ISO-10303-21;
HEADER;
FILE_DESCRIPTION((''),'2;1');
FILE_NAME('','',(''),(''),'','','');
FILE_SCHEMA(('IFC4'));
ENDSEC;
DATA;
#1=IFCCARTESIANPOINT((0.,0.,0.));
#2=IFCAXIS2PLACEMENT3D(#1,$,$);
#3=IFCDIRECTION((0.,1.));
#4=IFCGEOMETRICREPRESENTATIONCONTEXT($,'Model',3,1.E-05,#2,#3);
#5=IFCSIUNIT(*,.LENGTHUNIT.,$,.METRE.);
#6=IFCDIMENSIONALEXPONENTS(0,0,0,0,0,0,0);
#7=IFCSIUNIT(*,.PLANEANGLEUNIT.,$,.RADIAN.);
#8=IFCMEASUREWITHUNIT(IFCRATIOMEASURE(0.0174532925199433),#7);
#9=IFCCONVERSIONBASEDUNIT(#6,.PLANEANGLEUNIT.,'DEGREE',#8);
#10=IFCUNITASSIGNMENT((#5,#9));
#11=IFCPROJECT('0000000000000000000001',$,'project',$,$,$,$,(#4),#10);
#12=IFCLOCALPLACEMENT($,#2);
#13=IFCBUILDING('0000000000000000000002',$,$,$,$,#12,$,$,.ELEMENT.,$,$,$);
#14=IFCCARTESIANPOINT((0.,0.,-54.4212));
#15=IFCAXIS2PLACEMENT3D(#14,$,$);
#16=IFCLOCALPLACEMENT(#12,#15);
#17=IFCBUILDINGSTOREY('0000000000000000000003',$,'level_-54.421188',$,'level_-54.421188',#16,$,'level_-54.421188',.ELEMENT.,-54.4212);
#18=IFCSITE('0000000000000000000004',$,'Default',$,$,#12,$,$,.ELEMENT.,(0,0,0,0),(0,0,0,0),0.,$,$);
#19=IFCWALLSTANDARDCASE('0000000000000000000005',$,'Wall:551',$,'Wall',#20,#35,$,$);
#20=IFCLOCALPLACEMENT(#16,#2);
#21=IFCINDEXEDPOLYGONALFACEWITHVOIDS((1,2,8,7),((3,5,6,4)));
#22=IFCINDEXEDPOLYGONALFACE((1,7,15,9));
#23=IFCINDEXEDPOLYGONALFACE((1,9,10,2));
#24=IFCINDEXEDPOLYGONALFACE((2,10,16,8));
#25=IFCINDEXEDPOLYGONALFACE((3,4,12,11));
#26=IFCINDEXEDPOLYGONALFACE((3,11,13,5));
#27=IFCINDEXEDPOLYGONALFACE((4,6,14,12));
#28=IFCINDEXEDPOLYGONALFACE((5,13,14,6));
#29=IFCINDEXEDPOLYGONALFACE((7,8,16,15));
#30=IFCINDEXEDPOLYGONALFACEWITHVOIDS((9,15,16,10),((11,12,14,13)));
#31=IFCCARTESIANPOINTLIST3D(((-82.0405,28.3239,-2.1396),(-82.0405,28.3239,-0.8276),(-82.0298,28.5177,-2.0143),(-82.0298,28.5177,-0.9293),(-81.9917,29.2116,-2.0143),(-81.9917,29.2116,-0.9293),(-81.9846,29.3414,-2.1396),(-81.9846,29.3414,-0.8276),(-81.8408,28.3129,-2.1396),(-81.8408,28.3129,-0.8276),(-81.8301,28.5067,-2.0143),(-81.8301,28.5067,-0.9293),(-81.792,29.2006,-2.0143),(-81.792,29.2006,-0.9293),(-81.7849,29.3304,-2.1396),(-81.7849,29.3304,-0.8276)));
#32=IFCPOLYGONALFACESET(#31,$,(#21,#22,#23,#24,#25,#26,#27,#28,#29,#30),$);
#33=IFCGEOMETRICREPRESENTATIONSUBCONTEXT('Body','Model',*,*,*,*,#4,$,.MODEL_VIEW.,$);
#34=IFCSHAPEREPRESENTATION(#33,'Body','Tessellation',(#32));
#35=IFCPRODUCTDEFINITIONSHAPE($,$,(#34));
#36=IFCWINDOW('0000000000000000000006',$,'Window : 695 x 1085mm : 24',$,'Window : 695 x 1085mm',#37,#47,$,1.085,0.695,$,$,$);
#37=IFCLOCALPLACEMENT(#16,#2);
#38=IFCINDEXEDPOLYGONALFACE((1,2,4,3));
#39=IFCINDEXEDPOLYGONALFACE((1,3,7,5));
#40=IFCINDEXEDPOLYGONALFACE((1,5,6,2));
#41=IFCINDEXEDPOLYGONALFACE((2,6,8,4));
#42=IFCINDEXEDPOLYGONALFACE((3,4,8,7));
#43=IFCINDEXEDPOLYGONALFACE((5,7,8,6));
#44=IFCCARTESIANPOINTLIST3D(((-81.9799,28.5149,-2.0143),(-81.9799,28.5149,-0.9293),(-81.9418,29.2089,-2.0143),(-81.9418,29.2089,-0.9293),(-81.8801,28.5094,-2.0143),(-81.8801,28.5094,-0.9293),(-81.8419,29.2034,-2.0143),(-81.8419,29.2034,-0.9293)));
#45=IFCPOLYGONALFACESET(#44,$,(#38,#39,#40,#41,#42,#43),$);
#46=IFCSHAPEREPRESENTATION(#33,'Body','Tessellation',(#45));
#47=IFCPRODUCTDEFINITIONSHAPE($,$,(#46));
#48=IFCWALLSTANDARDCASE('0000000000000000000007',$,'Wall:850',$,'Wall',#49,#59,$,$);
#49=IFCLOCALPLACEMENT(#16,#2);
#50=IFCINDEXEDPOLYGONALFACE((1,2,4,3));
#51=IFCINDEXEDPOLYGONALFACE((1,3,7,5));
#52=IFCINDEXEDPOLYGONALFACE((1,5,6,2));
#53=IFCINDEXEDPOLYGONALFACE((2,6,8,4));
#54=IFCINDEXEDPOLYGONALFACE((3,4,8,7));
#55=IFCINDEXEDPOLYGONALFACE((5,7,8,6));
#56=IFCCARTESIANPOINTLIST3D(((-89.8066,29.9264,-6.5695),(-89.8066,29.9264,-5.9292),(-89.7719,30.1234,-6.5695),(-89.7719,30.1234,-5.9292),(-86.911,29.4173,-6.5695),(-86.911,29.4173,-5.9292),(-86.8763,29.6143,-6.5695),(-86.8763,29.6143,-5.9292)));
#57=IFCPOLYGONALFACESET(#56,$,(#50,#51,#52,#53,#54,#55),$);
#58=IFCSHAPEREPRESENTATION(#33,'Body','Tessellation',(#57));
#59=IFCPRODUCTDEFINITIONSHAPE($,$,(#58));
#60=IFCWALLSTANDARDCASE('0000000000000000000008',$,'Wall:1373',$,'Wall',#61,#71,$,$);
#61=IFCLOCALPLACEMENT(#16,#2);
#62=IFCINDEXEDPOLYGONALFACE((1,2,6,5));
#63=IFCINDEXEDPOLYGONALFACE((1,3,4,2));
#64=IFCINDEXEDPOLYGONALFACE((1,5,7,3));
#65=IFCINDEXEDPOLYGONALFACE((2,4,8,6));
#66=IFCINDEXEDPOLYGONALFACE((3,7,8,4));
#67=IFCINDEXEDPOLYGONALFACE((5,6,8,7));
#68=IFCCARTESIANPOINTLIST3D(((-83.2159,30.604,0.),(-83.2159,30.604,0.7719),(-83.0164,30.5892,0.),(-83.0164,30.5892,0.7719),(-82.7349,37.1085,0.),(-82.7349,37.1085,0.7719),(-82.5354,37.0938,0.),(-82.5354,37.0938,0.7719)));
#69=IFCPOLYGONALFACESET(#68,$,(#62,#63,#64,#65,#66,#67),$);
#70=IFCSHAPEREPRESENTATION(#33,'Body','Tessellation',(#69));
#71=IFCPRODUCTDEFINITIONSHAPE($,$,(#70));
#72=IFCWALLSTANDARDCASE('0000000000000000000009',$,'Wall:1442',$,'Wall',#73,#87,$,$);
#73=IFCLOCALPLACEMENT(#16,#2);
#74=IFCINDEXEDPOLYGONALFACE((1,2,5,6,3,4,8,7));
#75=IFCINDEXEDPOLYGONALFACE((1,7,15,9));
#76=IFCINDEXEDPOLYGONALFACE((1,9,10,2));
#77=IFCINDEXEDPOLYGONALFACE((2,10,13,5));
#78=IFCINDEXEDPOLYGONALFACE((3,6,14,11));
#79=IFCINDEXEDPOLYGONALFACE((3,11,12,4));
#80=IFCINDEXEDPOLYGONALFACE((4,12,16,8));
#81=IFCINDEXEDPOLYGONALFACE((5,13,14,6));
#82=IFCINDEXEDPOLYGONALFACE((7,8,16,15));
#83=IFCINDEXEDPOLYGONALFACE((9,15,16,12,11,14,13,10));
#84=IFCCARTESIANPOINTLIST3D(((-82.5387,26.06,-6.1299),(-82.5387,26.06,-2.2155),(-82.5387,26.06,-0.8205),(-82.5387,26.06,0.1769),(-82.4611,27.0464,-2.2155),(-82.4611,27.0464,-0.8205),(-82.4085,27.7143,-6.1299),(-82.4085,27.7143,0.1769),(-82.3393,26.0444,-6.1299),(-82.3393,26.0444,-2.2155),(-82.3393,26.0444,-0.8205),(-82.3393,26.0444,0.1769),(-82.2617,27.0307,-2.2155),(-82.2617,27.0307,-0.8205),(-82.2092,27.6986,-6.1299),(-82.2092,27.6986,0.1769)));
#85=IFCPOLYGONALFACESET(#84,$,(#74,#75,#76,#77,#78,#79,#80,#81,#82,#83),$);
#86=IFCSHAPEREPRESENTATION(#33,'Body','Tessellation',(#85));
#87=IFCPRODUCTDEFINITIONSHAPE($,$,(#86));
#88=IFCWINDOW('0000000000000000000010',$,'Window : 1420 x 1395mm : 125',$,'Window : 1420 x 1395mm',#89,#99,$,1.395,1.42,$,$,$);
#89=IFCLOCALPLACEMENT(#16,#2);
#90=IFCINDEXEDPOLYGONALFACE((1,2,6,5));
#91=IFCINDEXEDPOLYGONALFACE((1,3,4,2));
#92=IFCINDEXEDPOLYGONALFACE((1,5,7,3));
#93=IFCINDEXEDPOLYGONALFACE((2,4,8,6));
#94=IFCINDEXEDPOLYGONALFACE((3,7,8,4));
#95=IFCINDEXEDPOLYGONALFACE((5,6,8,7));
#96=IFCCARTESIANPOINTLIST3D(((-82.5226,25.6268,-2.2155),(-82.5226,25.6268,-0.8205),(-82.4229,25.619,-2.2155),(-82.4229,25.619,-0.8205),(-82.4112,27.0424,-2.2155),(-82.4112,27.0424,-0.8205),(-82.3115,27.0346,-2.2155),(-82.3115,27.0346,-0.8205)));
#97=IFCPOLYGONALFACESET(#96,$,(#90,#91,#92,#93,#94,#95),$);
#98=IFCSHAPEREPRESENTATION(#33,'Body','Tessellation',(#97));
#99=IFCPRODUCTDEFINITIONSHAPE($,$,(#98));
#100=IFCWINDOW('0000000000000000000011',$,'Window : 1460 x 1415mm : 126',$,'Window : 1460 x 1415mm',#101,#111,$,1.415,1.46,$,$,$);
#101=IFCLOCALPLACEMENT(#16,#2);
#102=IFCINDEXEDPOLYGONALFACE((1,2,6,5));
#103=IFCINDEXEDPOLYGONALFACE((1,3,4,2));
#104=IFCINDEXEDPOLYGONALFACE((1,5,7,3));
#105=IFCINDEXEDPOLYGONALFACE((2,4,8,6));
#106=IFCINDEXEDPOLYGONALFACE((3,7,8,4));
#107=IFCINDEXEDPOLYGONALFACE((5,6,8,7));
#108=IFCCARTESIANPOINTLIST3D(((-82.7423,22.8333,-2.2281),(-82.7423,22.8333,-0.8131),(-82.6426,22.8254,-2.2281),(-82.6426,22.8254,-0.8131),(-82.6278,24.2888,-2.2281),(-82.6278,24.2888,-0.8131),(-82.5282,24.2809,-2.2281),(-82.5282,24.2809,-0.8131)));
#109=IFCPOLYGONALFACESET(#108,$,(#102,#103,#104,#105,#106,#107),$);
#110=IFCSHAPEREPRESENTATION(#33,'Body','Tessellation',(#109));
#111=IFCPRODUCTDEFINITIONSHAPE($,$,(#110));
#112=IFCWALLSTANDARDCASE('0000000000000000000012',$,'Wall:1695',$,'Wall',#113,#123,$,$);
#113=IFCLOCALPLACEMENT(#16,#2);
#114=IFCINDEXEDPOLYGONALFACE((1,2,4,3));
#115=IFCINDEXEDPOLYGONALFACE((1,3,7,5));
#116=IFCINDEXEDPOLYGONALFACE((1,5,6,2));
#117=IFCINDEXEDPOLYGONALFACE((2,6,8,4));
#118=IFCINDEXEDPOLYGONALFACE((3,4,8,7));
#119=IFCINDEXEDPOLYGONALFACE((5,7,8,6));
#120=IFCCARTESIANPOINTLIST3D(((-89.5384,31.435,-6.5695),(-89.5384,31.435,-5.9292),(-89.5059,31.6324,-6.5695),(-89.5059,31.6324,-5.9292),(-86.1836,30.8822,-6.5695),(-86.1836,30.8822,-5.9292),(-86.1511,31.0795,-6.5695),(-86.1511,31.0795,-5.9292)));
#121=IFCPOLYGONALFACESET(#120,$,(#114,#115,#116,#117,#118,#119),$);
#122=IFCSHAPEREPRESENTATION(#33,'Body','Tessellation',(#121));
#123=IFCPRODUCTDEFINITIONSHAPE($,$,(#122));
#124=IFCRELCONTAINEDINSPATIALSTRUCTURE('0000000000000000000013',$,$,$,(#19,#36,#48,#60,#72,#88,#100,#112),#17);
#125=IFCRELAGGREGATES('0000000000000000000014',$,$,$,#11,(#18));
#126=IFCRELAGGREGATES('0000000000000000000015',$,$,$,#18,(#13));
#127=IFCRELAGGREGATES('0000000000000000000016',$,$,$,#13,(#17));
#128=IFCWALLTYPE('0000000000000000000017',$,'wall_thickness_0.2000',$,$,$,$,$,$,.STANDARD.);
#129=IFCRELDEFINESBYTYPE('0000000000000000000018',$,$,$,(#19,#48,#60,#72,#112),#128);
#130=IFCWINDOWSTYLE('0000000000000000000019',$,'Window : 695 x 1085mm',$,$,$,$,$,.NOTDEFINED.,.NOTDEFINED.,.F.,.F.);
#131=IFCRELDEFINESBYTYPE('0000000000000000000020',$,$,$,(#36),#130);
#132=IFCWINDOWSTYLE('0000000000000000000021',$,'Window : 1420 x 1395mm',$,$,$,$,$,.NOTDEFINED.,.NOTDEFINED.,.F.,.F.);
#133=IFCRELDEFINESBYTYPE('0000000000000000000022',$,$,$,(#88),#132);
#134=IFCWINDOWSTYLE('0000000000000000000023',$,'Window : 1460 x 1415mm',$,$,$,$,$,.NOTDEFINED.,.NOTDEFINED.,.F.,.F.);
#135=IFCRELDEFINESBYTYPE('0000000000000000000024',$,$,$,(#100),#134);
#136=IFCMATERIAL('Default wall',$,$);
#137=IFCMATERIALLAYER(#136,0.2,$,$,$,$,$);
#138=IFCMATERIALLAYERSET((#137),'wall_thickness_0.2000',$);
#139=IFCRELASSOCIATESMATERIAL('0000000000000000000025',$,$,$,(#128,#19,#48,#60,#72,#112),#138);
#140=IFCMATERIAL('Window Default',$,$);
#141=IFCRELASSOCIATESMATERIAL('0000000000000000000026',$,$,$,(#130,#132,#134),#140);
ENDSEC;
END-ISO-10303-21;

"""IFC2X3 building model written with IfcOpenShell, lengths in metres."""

from ifc_helpers import new_model, entity, si_unit, converted_unit, direction, frame, frame_2d, origin, origin_2d_with_axis, place, context, subcontext, project, spatial, polyline, rectangle, outline, extrude, source, transform, mapped, material, layer, layer_set, layer_usage, type_object, type_shapes, element, fill, save


model = new_model("IFC2X3")

# Units and contexts
model_context = context("Model", 3, precision=1e-05, world=origin(), true_north=direction((0.0, 1.0)))
body_context = subcontext(model_context, "Body", "Model", "MODEL_VIEW")
ifc_project = project(units=[si_unit("LENGTHUNIT", "METRE"), converted_unit("PLANEANGLEUNIT", "DEGREE", entity("IfcRatioMeasure", 0.0174532925199433), si_unit("PLANEANGLEUNIT", "RADIAN"), dimensions=[0, 0, 0, 0, 0, 0, 0])], contexts=[model_context])

# Site, building, storey
placement_1 = place(None, origin())
site = spatial("IfcSite", under=ifc_project, at=placement_1, Name="Default", CompositionType="ELEMENT", RefLatitude=(0, 0, 0, 0), RefLongitude=(0, 0, 0, 0), RefElevation=0.0)
building = spatial("IfcBuilding", under=site, at=placement_1, CompositionType="ELEMENT")
storey_placement = place(placement_1, frame((0.0, 0.0, -54.4212)))
storey = spatial("IfcBuildingStorey", under=building, at=storey_placement, Name="level_-54.421188", ObjectType="level_-54.421188", LongName="level_-54.421188", CompositionType="ELEMENT", Elevation=-54.4212)

# Wall, opening, window
ifc_material_1 = material(Name="Default wall")
ifc_layer = layer(ifc_material_1, 0.2)
ifc_layer_set = layer_set([ifc_layer], Name="wall_thickness_0.2000")
ifc_layer_usage = layer_usage(ifc_layer_set, "AXIS2", "POSITIVE", -0.1)
wall_type = type_object("IfcWallType", Name="wall_thickness_0.2000", PredefinedType="STANDARD", material=ifc_layer_set)
placement_2 = place(placement_1, frame((0.0, 0.0, -56.5608)))
wall_1_placement = place(placement_2, frame((-81.8847, 29.3359, 0.0), z_axis=(0.0, 0.0, 1.0), x_axis=(-0.054894, -0.998492, 0.0)))
wall_1 = element("IfcWallStandardCase", 1, at=wall_1_placement, inside=storey, type_object=wall_type, material=ifc_layer_usage, Name="Wall:551", ObjectType="Wall", context=body_context, shape_type="SweptSolid", body=[
    extrude(outline(polyline([(1.019, -0.1), (1.019, 0.1), (0.0, 0.1), (0.0, -0.1), (1.019, -0.1)])), origin(), (0.0, 0.0, 1.0), 1.312),
])
opening_1_placement = place(wall_1_placement, frame((0.13, -0.1, 0.1254)))
opening_1 = element("IfcOpeningElement", 2, at=opening_1_placement, cuts=wall_1, ObjectType="Opening", context=body_context, shape_type="SweptSolid", body=[
    extrude(rectangle(XDim=0.695, YDim=1.085, at=frame_2d((0.5425, 0.3475), x_axis=(0.0, 1.0))), frame((0.0, 0.0, 0.0), z_axis=(0.0, 1.0, 0.0), x_axis=(0.0, 0.0, 1.0)), (0.0, 0.0, 1.0), 0.2),
])
ifc_material_2 = material(Name="Window Default")
window_style_1 = type_object("IfcWindowStyle", Name="Window : 695 x 1085mm", ConstructionType="NOTDEFINED", OperationType="NOTDEFINED", ParameterTakesPrecedence=False, Sizeable=False, material=ifc_material_2)
shared_shape_1 = source(origin(), body_context, "Body", "SweptSolid", [
    extrude(rectangle(XDim=0.1, YDim=0.695, at=origin_2d_with_axis()), frame((0.3475, 0.1, 0.0), z_axis=(0.0, 0.0, 1.0), x_axis=(0.0, 1.0, 0.0)), (0.0, 0.0, 1.0), 1.085),
])
type_shapes(window_style_1, [shared_shape_1])
window_1_placement = place(opening_1_placement, origin())
window_1 = element("IfcWindow", 3, at=window_1_placement, inside=storey, type_object=window_style_1, Name="Window : 695 x 1085mm : 24", ObjectType="Window : 695 x 1085mm", OverallHeight=1.085, OverallWidth=0.695, context=body_context, shape_type="MappedRepresentation", body=[
    mapped(shared_shape_1, transform((0.0, 0.0, 0.0), scale=1.0)),
])
fill(opening_1, window_1)

# Walls
placement_3 = place(placement_1, frame((0.0, 0.0, -60.9907)))
wall_2_placement = place(placement_3, frame((-89.7892, 30.0249, 0.0), z_axis=(0.0, 0.0, 1.0), x_axis=(0.984895, -0.173154, 0.0)))
element("IfcWallStandardCase", 4, at=wall_2_placement, inside=storey, type_object=wall_type, material=ifc_layer_usage, Name="Wall:850", ObjectType="Wall", context=body_context, shape_type="SweptSolid", body=[
    extrude(outline(polyline([(2.94, -0.1), (2.94, 0.1), (0.0, 0.1), (0.0, -0.1), (2.94, -0.1)])), origin(), (0.0, 0.0, 1.0), 0.6403),
])
wall_3_placement = place(storey_placement, frame((-83.1162, 30.5966, 0.0), z_axis=(0.0, 0.0, 1.0), x_axis=(0.073744, 0.997277, 0.0)))
element("IfcWallStandardCase", 5, at=wall_3_placement, inside=storey, type_object=wall_type, material=ifc_layer_usage, Name="Wall:1373", ObjectType="Wall", context=body_context, shape_type="SweptSolid", body=[
    extrude(outline(polyline([(6.5223, -0.1), (6.5223, 0.1), (0.0, 0.1), (0.0, -0.1), (6.5223, -0.1)])), origin(), (0.0, 0.0, 1.0), 0.7719),
])

# Wall, openings, windows
placement_4 = place(placement_1, frame((0.0, 0.0, -60.5511)))
wall_4_placement = place(placement_4, frame((-82.3088, 27.7065, 0.0), z_axis=(0.0, 0.0, 1.0), x_axis=(-0.07842, -0.99692, 0.0)))
wall_4 = element("IfcWallStandardCase", 6, at=wall_4_placement, inside=storey, type_object=wall_type, material=ifc_layer_usage, Name="Wall:1442", ObjectType="Wall", context=body_context, shape_type="SweptSolid", body=[
    extrude(outline(polyline([(1.6594, -0.1), (1.6594, 0.1), (0.0, 0.1), (0.0, -0.1), (1.6594, -0.1)])), origin(), (0.0, 0.0, 1.0), 6.3068),
])
opening_2_placement = place(wall_4_placement, frame((0.67, -0.1, 3.9145)))
opening_2 = element("IfcOpeningElement", 7, at=opening_2_placement, cuts=wall_4, ObjectType="Opening", context=body_context, shape_type="SweptSolid", body=[
    extrude(rectangle(XDim=1.42, YDim=1.395, at=frame_2d((0.6975, 0.71), x_axis=(0.0, 1.0))), frame((0.0, 0.0, 0.0), z_axis=(0.0, 1.0, 0.0), x_axis=(0.0, 0.0, 1.0)), (0.0, 0.0, 1.0), 0.2),
])
opening_3_placement = place(wall_4_placement, frame((3.4322, -0.1, 3.9018)))
opening_3 = element("IfcOpeningElement", 8, at=opening_3_placement, cuts=wall_4, ObjectType="Opening", context=body_context, shape_type="SweptSolid", body=[
    extrude(rectangle(XDim=1.46, YDim=1.415, at=frame_2d((0.7075, 0.73), x_axis=(0.0, 1.0))), frame((0.0, 0.0, 0.0), z_axis=(0.0, 1.0, 0.0), x_axis=(0.0, 0.0, 1.0)), (0.0, 0.0, 1.0), 0.2),
])
window_style_2 = type_object("IfcWindowStyle", Name="Window : 1420 x 1395mm", ConstructionType="NOTDEFINED", OperationType="NOTDEFINED", ParameterTakesPrecedence=False, Sizeable=False, material=ifc_material_2)
shared_shape_2 = source(origin(), body_context, "Body", "SweptSolid", [
    extrude(rectangle(XDim=0.1, YDim=1.42, at=origin_2d_with_axis()), frame((0.71, 0.1, 0.0), z_axis=(0.0, 0.0, 1.0), x_axis=(0.0, 1.0, 0.0)), (0.0, 0.0, 1.0), 1.395),
])
type_shapes(window_style_2, [shared_shape_2])
window_2_placement = place(opening_2_placement, origin())
window_2 = element("IfcWindow", 9, at=window_2_placement, inside=storey, type_object=window_style_2, Name="Window : 1420 x 1395mm : 125", ObjectType="Window : 1420 x 1395mm", OverallHeight=1.395, OverallWidth=1.42, context=body_context, shape_type="MappedRepresentation", body=[
    mapped(shared_shape_2, transform((0.0, 0.0, 0.0), scale=1.0)),
])
fill(opening_2, window_2)
window_style_3 = type_object("IfcWindowStyle", Name="Window : 1460 x 1415mm", ConstructionType="NOTDEFINED", OperationType="NOTDEFINED", ParameterTakesPrecedence=False, Sizeable=False, material=ifc_material_2)
shared_shape_3 = source(origin(), body_context, "Body", "SweptSolid", [
    extrude(rectangle(XDim=0.1, YDim=1.46, at=origin_2d_with_axis()), frame((0.73, 0.1, 0.0), z_axis=(0.0, 0.0, 1.0), x_axis=(0.0, 1.0, 0.0)), (0.0, 0.0, 1.0), 1.415),
])
type_shapes(window_style_3, [shared_shape_3])
window_3_placement = place(opening_3_placement, origin())
window_3 = element("IfcWindow", 10, at=window_3_placement, inside=storey, type_object=window_style_3, Name="Window : 1460 x 1415mm : 126", ObjectType="Window : 1460 x 1415mm", OverallHeight=1.415, OverallWidth=1.46, context=body_context, shape_type="MappedRepresentation", body=[
    mapped(shared_shape_3, transform((0.0, 0.0, 0.0), scale=1.0)),
])
fill(opening_3, window_3)

# Wall
placement_5 = place(placement_1, frame((0.0, 0.0, -60.9907)))
wall_5_placement = place(placement_5, frame((-89.5221, 31.5337, 0.0), z_axis=(0.0, 0.0, 1.0), x_axis=(0.986691, -0.162606, 0.0)))
element("IfcWallStandardCase", 11, at=wall_5_placement, inside=storey, type_object=wall_type, material=ifc_layer_usage, Name="Wall:1695", ObjectType="Wall", context=body_context, shape_type="SweptSolid", body=[
    extrude(outline(polyline([(3.4, -0.1), (3.4, 0.1), (0.0, 0.1), (0.0, -0.1), (3.4, -0.1)])), origin(), (0.0, 0.0, 1.0), 0.6403),
])

save(model, "model.ifc")
